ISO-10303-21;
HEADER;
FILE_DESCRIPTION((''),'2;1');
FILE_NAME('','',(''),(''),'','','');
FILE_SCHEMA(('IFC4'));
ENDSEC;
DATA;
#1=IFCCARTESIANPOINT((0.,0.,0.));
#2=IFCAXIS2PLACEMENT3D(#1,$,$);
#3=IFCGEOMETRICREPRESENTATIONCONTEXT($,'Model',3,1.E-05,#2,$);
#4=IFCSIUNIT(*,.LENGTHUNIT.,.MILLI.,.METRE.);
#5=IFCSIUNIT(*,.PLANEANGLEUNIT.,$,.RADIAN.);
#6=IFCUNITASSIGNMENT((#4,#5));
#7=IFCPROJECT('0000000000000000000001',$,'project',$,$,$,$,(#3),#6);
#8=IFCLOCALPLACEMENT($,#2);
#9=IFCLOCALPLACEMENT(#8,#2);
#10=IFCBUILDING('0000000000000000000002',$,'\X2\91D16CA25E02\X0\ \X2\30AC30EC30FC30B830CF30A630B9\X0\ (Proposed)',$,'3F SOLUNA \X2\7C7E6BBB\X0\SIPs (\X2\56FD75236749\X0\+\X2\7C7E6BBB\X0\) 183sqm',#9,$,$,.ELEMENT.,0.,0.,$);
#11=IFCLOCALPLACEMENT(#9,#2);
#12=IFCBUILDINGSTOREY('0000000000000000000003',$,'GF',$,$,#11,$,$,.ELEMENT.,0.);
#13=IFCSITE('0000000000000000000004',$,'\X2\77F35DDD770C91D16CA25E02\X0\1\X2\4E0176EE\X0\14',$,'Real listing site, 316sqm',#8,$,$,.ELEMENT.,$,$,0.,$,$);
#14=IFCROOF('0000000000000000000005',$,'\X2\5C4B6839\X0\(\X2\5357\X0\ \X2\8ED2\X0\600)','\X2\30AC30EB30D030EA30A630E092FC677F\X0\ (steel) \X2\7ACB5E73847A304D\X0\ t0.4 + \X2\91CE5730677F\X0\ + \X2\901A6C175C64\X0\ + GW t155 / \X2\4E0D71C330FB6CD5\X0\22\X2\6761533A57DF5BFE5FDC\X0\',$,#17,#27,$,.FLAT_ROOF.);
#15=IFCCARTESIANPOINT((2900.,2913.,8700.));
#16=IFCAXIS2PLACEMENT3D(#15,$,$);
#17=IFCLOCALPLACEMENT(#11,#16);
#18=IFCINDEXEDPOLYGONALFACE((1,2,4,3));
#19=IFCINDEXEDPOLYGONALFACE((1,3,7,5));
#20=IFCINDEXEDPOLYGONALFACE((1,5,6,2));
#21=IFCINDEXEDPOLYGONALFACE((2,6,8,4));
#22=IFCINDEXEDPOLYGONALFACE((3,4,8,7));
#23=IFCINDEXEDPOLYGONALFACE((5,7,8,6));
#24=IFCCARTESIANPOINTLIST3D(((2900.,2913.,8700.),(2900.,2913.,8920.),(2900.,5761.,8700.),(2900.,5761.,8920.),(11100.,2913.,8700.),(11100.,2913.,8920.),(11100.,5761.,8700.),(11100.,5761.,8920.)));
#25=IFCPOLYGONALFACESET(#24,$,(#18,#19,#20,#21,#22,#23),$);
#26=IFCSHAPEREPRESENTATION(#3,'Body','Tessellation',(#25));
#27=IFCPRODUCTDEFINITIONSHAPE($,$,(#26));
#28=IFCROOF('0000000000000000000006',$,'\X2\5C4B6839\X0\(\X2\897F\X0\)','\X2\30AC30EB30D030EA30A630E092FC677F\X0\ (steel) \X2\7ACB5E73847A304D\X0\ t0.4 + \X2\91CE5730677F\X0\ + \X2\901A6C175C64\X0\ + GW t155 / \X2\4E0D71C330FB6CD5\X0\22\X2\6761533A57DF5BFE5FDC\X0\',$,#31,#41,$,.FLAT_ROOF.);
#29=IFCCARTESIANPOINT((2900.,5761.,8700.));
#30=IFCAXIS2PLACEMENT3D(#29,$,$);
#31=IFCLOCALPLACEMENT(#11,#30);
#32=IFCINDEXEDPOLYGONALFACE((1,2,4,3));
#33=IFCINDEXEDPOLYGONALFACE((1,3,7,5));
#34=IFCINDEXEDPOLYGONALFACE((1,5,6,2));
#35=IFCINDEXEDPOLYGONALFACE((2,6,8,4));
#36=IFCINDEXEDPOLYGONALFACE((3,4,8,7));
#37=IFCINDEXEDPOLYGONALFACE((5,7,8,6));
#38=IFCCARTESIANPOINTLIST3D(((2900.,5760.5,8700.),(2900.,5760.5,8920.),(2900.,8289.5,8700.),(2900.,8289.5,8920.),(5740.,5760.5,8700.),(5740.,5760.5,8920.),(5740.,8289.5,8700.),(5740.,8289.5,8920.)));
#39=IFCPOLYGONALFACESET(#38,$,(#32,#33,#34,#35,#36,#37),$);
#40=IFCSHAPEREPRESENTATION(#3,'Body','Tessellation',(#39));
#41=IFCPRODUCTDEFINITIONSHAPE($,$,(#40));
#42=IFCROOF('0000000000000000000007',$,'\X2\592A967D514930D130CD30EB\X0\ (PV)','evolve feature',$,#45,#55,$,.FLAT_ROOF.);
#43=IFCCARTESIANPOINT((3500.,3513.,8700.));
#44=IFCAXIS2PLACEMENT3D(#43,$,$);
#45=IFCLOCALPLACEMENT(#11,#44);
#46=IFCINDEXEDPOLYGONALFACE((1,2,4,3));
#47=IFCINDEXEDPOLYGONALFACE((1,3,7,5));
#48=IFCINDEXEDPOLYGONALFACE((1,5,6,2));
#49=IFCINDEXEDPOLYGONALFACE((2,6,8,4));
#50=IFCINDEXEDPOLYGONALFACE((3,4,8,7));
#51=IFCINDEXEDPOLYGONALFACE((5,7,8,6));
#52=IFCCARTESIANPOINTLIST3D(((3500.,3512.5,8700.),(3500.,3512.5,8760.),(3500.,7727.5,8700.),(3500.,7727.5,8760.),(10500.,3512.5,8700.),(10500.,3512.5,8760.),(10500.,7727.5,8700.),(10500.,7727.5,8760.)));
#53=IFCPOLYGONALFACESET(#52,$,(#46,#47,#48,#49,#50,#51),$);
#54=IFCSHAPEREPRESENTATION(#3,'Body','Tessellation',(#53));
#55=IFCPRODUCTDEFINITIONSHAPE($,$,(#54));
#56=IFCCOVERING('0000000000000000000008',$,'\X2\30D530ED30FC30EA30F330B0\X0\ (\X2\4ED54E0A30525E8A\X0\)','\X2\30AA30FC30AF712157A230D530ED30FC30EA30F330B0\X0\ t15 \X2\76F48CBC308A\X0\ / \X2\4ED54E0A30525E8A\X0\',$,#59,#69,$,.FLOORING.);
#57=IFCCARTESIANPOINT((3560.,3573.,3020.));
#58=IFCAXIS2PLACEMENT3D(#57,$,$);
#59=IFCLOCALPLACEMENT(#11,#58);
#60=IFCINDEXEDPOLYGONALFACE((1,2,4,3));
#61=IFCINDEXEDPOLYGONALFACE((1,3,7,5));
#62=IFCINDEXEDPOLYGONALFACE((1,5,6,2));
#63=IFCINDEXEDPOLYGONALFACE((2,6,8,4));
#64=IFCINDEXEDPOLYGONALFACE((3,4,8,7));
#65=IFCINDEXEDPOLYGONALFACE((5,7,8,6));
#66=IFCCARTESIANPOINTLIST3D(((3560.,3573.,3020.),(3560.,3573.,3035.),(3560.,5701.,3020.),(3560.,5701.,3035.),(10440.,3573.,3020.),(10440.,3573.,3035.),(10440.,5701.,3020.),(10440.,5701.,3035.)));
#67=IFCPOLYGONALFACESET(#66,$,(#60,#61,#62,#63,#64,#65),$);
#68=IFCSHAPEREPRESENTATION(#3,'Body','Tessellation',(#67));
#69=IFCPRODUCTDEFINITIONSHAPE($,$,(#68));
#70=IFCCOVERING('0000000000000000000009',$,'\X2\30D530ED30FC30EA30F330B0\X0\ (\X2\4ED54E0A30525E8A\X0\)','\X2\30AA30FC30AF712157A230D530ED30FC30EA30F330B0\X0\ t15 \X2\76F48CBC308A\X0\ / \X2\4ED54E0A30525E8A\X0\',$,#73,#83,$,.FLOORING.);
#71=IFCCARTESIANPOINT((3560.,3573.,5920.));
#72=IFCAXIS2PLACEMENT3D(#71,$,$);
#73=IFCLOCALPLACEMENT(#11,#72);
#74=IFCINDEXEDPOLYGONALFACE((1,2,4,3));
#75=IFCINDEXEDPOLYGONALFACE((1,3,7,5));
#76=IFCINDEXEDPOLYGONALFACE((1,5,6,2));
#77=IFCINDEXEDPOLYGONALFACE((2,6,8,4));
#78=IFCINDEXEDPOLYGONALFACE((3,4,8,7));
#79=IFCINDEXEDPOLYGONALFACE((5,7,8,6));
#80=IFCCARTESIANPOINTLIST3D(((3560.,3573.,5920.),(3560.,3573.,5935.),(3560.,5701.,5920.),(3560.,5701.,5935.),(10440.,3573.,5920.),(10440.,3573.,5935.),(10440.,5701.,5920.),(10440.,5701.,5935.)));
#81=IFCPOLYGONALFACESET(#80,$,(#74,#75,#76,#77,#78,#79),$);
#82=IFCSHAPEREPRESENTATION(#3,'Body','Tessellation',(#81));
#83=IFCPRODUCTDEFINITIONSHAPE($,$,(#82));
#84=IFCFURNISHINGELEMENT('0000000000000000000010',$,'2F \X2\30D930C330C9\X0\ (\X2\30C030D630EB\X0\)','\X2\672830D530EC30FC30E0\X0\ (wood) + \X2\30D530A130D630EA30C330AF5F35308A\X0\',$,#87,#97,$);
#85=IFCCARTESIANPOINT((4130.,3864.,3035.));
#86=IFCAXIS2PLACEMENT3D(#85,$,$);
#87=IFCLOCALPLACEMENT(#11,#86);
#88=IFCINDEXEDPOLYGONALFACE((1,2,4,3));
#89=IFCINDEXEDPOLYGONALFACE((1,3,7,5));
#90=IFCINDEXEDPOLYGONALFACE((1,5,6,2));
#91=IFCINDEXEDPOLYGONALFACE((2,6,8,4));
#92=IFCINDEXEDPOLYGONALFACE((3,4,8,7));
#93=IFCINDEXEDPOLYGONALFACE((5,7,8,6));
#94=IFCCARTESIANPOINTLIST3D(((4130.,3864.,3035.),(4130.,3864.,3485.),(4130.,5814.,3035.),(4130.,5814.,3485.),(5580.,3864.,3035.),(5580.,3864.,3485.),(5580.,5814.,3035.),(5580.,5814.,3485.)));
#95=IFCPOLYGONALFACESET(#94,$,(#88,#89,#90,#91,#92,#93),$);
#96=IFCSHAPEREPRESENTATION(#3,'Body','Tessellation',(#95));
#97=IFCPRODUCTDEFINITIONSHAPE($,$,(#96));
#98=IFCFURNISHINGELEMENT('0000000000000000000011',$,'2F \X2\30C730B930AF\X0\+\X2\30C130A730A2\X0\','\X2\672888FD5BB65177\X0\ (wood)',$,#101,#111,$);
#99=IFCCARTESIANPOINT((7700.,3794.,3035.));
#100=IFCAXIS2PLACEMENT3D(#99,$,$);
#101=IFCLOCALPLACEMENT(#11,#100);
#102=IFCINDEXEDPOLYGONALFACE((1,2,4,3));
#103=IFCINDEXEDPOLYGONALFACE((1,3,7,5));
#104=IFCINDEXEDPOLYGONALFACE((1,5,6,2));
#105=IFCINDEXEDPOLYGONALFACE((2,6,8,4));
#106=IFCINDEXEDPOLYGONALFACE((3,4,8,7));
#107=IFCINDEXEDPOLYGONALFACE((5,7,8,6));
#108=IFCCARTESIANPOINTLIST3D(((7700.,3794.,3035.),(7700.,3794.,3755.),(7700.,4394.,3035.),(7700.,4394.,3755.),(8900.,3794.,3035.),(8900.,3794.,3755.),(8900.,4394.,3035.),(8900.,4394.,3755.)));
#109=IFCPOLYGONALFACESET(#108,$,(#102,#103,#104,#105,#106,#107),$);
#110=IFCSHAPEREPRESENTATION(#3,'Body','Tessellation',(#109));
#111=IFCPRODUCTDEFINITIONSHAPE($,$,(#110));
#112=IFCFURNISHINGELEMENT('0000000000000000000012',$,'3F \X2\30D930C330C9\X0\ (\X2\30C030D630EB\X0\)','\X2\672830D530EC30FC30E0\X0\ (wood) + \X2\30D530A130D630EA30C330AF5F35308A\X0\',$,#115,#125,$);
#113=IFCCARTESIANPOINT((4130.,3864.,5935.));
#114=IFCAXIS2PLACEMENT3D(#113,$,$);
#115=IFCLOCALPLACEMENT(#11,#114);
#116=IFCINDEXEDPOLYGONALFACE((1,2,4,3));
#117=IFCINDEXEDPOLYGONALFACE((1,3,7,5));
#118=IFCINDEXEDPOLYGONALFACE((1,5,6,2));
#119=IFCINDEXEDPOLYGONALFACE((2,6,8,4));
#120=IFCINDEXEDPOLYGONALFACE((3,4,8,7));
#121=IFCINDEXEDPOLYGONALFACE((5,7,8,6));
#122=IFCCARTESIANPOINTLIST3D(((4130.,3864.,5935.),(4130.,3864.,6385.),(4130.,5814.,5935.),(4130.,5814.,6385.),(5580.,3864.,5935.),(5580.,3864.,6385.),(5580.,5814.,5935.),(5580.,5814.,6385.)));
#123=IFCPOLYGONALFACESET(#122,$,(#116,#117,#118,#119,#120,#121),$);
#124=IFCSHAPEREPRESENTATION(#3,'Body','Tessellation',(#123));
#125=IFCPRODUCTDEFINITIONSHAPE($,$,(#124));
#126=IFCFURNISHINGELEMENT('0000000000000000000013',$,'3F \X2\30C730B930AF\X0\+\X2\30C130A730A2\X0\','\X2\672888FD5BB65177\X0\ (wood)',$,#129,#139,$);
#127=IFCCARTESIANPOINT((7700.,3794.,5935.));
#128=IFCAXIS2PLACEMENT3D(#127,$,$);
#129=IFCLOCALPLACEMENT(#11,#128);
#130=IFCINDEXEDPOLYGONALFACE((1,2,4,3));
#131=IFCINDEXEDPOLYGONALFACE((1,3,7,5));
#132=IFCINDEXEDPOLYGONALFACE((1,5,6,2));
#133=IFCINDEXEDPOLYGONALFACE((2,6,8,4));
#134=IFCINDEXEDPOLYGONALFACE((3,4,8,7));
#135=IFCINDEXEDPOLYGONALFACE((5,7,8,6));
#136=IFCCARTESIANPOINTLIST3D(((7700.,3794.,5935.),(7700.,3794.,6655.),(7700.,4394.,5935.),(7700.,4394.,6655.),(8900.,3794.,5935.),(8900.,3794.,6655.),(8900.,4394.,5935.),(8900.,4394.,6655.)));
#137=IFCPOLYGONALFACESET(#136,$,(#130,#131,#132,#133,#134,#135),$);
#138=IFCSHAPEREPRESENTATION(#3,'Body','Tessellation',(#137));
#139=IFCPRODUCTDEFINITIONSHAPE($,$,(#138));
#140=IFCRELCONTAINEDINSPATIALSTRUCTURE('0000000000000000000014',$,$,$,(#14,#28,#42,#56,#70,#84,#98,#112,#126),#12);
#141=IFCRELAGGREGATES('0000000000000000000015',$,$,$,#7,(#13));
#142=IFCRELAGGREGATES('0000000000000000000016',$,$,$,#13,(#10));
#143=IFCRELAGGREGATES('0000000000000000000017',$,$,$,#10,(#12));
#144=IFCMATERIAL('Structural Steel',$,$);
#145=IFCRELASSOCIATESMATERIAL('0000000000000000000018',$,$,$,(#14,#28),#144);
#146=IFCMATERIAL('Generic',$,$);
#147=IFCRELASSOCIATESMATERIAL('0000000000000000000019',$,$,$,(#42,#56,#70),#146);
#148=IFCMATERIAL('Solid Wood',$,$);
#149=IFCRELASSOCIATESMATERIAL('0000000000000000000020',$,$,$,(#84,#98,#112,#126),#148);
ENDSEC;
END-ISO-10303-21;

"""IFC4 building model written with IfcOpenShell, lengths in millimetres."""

from ifc_helpers import new_model, si_unit, frame, frame_2d, origin, place, context, project, spatial, rectangle, extrude, material, element, save


model = new_model("IFC4")

# Units and contexts
model_context = context("Model", 3, precision=1e-05, world=origin())
ifc_project = project(units=[si_unit("LENGTHUNIT", "METRE", prefix="MILLI"), si_unit("PLANEANGLEUNIT", "RADIAN")], contexts=[model_context])

# Site, building, storey
site_placement = place(None, origin())
site = spatial("IfcSite", under=ifc_project, at=site_placement, Name="石川県金沢市1丁目14", ObjectType="Real listing site, 316sqm", CompositionType="ELEMENT", RefElevation=0.0)
building_placement = place(site_placement, origin())
building = spatial("IfcBuilding", under=site, at=building_placement, Name="金沢市 ガレージハウス (Proposed)", ObjectType="3F SOLUNA 籾殻SIPs (国産杉+籾殻) 183sqm", CompositionType="ELEMENT", ElevationOfRefHeight=0.0, ElevationOfTerrain=0.0)
storey_placement = place(building_placement, origin())
storey = spatial("IfcBuildingStorey", under=building, at=storey_placement, Name="GF", CompositionType="ELEMENT", Elevation=0.0)

# Shared definitions
ifc_material_1 = material(Name="Solid Wood")

# Roofs
ifc_material_2 = material(Name="Structural Steel")
roof_1_placement = place(storey_placement, frame((2900.0, 2913.0, 8700.0)))
element("IfcRoof", 1, at=roof_1_placement, inside=storey, material=ifc_material_2, Name="屋根(南 軒600)", Description="ガルバリウム鋼板 (steel) 立平葺き t0.4 + 野地板 + 通気層 + GW t155 / 不燃・法22条区域対応", PredefinedType="FLAT_ROOF", context=model_context, shape_type="SweptSolid", body=[
    extrude(rectangle(XDim=8200.0, YDim=2848.0, at=frame_2d((4100.0, 1424.0))), frame((2900.0, 2913.0, 8700.0)), (0.0, 0.0, 1.0), 220.0),
])
roof_2_placement = place(storey_placement, frame((2900.0, 5761.0, 8700.0)))
element("IfcRoof", 2, at=roof_2_placement, inside=storey, material=ifc_material_2, Name="屋根(西)", Description="ガルバリウム鋼板 (steel) 立平葺き t0.4 + 野地板 + 通気層 + GW t155 / 不燃・法22条区域対応", PredefinedType="FLAT_ROOF", context=model_context, shape_type="SweptSolid", body=[
    extrude(rectangle(XDim=2840.0, YDim=2529.0, at=frame_2d((1420.0, 1264.0))), frame((2900.0, 5761.0, 8700.0)), (0.0, 0.0, 1.0), 220.0),
])
ifc_material_3 = material(Name="Generic")
roof_3_placement = place(storey_placement, frame((3500.0, 3513.0, 8700.0)))
element("IfcRoof", 3, at=roof_3_placement, inside=storey, material=ifc_material_3, Name="太陽光パネル (PV)", Description="evolve feature", PredefinedType="FLAT_ROOF", context=model_context, shape_type="SweptSolid", body=[
    extrude(rectangle(XDim=7000.0, YDim=4215.0, at=frame_2d((3500.0, 2107.0))), frame((3500.0, 3513.0, 8700.0)), (0.0, 0.0, 1.0), 60.0),
])

# Coverings
covering_1_placement = place(storey_placement, frame((3560.0, 3573.0, 3020.0)))
element("IfcCovering", 4, at=covering_1_placement, inside=storey, material=ifc_material_3, Name="フローリング (仕上げ床)", Description="オーク無垢フローリング t15 直貼り / 仕上げ床", PredefinedType="FLOORING", context=model_context, shape_type="SweptSolid", body=[
    extrude(rectangle(XDim=6880.0, YDim=2128.0, at=frame_2d((3440.0, 1064.0))), frame((3560.0, 3573.0, 3020.0)), (0.0, 0.0, 1.0), 15.0),
])
covering_2_placement = place(storey_placement, frame((3560.0, 3573.0, 5920.0)))
element("IfcCovering", 5, at=covering_2_placement, inside=storey, material=ifc_material_3, Name="フローリング (仕上げ床)", Description="オーク無垢フローリング t15 直貼り / 仕上げ床", PredefinedType="FLOORING", context=model_context, shape_type="SweptSolid", body=[
    extrude(rectangle(XDim=6880.0, YDim=2128.0, at=frame_2d((3440.0, 1064.0))), frame((3560.0, 3573.0, 5920.0)), (0.0, 0.0, 1.0), 15.0),
])

# Furnishing elements
furnishing_1_placement = place(storey_placement, frame((4130.0, 3864.0, 3035.0)))
element("IfcFurnishingElement", 6, at=furnishing_1_placement, inside=storey, material=ifc_material_1, Name="2F ベッド (ダブル)", Description="木フレーム (wood) + ファブリック張り", context=model_context, shape_type="SweptSolid", body=[
    extrude(rectangle(XDim=1450.0, YDim=1950.0, at=frame_2d((725.0, 975.0))), frame((4130.0, 3864.0, 3035.0)), (0.0, 0.0, 1.0), 450.0),
])
furnishing_2_placement = place(storey_placement, frame((7700.0, 3794.0, 3035.0)))
element("IfcFurnishingElement", 7, at=furnishing_2_placement, inside=storey, material=ifc_material_1, Name="2F デスク+チェア", Description="木製家具 (wood)", context=model_context, shape_type="SweptSolid", body=[
    extrude(rectangle(XDim=1200.0, YDim=600.0, at=frame_2d((600.0, 300.0))), frame((7700.0, 3794.0, 3035.0)), (0.0, 0.0, 1.0), 720.0),
])
furnishing_3_placement = place(storey_placement, frame((4130.0, 3864.0, 5935.0)))
element("IfcFurnishingElement", 8, at=furnishing_3_placement, inside=storey, material=ifc_material_1, Name="3F ベッド (ダブル)", Description="木フレーム (wood) + ファブリック張り", context=model_context, shape_type="SweptSolid", body=[
    extrude(rectangle(XDim=1450.0, YDim=1950.0, at=frame_2d((725.0, 975.0))), frame((4130.0, 3864.0, 5935.0)), (0.0, 0.0, 1.0), 450.0),
])
furnishing_4_placement = place(storey_placement, frame((7700.0, 3794.0, 5935.0)))
element("IfcFurnishingElement", 9, at=furnishing_4_placement, inside=storey, material=ifc_material_1, Name="3F デスク+チェア", Description="木製家具 (wood)", context=model_context, shape_type="SweptSolid", body=[
    extrude(rectangle(XDim=1200.0, YDim=600.0, at=frame_2d((600.0, 300.0))), frame((7700.0, 3794.0, 5935.0)), (0.0, 0.0, 1.0), 720.0),
])

save(model, "model.ifc")
